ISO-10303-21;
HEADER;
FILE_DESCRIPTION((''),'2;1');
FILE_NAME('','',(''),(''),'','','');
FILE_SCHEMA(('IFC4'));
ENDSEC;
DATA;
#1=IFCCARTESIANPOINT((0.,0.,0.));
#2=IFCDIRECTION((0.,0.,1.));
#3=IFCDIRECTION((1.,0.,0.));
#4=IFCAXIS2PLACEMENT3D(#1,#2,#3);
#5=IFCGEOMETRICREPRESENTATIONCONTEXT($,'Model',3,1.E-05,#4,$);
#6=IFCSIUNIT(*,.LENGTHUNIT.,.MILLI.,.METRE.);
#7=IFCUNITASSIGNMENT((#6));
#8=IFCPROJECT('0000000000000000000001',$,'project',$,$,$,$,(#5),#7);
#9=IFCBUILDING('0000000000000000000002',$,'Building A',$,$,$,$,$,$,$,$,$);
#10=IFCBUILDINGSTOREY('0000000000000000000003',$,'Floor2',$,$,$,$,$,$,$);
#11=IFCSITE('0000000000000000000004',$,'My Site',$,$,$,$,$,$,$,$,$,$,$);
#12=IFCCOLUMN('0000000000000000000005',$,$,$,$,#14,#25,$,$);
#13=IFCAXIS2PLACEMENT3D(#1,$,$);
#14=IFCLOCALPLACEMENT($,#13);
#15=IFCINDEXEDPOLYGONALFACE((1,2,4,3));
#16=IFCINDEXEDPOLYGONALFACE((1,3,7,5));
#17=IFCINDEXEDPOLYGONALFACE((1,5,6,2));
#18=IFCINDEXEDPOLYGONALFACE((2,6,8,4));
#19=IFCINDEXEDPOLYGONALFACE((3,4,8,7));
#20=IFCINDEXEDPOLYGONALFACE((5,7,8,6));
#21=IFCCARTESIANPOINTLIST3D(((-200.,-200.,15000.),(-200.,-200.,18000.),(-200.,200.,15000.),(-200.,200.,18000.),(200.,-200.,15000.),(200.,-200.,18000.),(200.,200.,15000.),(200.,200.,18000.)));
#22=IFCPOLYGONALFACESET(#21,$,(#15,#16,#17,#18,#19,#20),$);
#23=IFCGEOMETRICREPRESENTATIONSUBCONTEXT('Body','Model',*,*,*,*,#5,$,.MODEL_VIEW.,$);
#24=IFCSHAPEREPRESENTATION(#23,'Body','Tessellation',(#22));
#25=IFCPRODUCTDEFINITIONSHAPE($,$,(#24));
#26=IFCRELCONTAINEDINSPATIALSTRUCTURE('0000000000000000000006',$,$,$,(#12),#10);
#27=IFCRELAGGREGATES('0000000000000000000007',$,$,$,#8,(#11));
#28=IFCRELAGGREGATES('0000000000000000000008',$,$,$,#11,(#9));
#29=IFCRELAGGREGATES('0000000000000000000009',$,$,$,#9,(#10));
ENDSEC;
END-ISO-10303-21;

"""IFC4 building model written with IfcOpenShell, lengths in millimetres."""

from ifc_helpers import new_model, si_unit, frame, origin_with_axes, place, context, subcontext, project, spatial, line, indexed_curve, outline, extrude, element, save


model = new_model("IFC4")

# Units and contexts
model_context = context("Model", 3, precision=1e-05, world=origin_with_axes())
body_context = subcontext(model_context, "Body", "Model", "MODEL_VIEW")
ifc_project = project(units=[si_unit("LENGTHUNIT", "METRE", prefix="MILLI")], contexts=[model_context])

# Site, building, storey
site = spatial("IfcSite", under=ifc_project, Name="My Site")
building = spatial("IfcBuilding", under=site, Name="Building A")
storey = spatial("IfcBuildingStorey", under=building, Name="Floor2")

# Column
column_placement = place(None, frame((0.0, 0.0, 15000.0), z_axis=(0.0, 0.0, 1.0), x_axis=(1.0, 0.0, 0.0)))
element("IfcColumn", 1, at=column_placement, inside=storey, context=body_context, shape_type="SweptSolid", body=[
    extrude(outline(indexed_curve([(-200.0, -200.0), (200.0, -200.0), (200.0, 200.0), (-200.0, 200.0)], segments=[line(1, 2, 3, 4, 1)])), origin_with_axes(), (0.0, 0.0, 1.0), 3000.0),
])

save(model, "model.ifc")
